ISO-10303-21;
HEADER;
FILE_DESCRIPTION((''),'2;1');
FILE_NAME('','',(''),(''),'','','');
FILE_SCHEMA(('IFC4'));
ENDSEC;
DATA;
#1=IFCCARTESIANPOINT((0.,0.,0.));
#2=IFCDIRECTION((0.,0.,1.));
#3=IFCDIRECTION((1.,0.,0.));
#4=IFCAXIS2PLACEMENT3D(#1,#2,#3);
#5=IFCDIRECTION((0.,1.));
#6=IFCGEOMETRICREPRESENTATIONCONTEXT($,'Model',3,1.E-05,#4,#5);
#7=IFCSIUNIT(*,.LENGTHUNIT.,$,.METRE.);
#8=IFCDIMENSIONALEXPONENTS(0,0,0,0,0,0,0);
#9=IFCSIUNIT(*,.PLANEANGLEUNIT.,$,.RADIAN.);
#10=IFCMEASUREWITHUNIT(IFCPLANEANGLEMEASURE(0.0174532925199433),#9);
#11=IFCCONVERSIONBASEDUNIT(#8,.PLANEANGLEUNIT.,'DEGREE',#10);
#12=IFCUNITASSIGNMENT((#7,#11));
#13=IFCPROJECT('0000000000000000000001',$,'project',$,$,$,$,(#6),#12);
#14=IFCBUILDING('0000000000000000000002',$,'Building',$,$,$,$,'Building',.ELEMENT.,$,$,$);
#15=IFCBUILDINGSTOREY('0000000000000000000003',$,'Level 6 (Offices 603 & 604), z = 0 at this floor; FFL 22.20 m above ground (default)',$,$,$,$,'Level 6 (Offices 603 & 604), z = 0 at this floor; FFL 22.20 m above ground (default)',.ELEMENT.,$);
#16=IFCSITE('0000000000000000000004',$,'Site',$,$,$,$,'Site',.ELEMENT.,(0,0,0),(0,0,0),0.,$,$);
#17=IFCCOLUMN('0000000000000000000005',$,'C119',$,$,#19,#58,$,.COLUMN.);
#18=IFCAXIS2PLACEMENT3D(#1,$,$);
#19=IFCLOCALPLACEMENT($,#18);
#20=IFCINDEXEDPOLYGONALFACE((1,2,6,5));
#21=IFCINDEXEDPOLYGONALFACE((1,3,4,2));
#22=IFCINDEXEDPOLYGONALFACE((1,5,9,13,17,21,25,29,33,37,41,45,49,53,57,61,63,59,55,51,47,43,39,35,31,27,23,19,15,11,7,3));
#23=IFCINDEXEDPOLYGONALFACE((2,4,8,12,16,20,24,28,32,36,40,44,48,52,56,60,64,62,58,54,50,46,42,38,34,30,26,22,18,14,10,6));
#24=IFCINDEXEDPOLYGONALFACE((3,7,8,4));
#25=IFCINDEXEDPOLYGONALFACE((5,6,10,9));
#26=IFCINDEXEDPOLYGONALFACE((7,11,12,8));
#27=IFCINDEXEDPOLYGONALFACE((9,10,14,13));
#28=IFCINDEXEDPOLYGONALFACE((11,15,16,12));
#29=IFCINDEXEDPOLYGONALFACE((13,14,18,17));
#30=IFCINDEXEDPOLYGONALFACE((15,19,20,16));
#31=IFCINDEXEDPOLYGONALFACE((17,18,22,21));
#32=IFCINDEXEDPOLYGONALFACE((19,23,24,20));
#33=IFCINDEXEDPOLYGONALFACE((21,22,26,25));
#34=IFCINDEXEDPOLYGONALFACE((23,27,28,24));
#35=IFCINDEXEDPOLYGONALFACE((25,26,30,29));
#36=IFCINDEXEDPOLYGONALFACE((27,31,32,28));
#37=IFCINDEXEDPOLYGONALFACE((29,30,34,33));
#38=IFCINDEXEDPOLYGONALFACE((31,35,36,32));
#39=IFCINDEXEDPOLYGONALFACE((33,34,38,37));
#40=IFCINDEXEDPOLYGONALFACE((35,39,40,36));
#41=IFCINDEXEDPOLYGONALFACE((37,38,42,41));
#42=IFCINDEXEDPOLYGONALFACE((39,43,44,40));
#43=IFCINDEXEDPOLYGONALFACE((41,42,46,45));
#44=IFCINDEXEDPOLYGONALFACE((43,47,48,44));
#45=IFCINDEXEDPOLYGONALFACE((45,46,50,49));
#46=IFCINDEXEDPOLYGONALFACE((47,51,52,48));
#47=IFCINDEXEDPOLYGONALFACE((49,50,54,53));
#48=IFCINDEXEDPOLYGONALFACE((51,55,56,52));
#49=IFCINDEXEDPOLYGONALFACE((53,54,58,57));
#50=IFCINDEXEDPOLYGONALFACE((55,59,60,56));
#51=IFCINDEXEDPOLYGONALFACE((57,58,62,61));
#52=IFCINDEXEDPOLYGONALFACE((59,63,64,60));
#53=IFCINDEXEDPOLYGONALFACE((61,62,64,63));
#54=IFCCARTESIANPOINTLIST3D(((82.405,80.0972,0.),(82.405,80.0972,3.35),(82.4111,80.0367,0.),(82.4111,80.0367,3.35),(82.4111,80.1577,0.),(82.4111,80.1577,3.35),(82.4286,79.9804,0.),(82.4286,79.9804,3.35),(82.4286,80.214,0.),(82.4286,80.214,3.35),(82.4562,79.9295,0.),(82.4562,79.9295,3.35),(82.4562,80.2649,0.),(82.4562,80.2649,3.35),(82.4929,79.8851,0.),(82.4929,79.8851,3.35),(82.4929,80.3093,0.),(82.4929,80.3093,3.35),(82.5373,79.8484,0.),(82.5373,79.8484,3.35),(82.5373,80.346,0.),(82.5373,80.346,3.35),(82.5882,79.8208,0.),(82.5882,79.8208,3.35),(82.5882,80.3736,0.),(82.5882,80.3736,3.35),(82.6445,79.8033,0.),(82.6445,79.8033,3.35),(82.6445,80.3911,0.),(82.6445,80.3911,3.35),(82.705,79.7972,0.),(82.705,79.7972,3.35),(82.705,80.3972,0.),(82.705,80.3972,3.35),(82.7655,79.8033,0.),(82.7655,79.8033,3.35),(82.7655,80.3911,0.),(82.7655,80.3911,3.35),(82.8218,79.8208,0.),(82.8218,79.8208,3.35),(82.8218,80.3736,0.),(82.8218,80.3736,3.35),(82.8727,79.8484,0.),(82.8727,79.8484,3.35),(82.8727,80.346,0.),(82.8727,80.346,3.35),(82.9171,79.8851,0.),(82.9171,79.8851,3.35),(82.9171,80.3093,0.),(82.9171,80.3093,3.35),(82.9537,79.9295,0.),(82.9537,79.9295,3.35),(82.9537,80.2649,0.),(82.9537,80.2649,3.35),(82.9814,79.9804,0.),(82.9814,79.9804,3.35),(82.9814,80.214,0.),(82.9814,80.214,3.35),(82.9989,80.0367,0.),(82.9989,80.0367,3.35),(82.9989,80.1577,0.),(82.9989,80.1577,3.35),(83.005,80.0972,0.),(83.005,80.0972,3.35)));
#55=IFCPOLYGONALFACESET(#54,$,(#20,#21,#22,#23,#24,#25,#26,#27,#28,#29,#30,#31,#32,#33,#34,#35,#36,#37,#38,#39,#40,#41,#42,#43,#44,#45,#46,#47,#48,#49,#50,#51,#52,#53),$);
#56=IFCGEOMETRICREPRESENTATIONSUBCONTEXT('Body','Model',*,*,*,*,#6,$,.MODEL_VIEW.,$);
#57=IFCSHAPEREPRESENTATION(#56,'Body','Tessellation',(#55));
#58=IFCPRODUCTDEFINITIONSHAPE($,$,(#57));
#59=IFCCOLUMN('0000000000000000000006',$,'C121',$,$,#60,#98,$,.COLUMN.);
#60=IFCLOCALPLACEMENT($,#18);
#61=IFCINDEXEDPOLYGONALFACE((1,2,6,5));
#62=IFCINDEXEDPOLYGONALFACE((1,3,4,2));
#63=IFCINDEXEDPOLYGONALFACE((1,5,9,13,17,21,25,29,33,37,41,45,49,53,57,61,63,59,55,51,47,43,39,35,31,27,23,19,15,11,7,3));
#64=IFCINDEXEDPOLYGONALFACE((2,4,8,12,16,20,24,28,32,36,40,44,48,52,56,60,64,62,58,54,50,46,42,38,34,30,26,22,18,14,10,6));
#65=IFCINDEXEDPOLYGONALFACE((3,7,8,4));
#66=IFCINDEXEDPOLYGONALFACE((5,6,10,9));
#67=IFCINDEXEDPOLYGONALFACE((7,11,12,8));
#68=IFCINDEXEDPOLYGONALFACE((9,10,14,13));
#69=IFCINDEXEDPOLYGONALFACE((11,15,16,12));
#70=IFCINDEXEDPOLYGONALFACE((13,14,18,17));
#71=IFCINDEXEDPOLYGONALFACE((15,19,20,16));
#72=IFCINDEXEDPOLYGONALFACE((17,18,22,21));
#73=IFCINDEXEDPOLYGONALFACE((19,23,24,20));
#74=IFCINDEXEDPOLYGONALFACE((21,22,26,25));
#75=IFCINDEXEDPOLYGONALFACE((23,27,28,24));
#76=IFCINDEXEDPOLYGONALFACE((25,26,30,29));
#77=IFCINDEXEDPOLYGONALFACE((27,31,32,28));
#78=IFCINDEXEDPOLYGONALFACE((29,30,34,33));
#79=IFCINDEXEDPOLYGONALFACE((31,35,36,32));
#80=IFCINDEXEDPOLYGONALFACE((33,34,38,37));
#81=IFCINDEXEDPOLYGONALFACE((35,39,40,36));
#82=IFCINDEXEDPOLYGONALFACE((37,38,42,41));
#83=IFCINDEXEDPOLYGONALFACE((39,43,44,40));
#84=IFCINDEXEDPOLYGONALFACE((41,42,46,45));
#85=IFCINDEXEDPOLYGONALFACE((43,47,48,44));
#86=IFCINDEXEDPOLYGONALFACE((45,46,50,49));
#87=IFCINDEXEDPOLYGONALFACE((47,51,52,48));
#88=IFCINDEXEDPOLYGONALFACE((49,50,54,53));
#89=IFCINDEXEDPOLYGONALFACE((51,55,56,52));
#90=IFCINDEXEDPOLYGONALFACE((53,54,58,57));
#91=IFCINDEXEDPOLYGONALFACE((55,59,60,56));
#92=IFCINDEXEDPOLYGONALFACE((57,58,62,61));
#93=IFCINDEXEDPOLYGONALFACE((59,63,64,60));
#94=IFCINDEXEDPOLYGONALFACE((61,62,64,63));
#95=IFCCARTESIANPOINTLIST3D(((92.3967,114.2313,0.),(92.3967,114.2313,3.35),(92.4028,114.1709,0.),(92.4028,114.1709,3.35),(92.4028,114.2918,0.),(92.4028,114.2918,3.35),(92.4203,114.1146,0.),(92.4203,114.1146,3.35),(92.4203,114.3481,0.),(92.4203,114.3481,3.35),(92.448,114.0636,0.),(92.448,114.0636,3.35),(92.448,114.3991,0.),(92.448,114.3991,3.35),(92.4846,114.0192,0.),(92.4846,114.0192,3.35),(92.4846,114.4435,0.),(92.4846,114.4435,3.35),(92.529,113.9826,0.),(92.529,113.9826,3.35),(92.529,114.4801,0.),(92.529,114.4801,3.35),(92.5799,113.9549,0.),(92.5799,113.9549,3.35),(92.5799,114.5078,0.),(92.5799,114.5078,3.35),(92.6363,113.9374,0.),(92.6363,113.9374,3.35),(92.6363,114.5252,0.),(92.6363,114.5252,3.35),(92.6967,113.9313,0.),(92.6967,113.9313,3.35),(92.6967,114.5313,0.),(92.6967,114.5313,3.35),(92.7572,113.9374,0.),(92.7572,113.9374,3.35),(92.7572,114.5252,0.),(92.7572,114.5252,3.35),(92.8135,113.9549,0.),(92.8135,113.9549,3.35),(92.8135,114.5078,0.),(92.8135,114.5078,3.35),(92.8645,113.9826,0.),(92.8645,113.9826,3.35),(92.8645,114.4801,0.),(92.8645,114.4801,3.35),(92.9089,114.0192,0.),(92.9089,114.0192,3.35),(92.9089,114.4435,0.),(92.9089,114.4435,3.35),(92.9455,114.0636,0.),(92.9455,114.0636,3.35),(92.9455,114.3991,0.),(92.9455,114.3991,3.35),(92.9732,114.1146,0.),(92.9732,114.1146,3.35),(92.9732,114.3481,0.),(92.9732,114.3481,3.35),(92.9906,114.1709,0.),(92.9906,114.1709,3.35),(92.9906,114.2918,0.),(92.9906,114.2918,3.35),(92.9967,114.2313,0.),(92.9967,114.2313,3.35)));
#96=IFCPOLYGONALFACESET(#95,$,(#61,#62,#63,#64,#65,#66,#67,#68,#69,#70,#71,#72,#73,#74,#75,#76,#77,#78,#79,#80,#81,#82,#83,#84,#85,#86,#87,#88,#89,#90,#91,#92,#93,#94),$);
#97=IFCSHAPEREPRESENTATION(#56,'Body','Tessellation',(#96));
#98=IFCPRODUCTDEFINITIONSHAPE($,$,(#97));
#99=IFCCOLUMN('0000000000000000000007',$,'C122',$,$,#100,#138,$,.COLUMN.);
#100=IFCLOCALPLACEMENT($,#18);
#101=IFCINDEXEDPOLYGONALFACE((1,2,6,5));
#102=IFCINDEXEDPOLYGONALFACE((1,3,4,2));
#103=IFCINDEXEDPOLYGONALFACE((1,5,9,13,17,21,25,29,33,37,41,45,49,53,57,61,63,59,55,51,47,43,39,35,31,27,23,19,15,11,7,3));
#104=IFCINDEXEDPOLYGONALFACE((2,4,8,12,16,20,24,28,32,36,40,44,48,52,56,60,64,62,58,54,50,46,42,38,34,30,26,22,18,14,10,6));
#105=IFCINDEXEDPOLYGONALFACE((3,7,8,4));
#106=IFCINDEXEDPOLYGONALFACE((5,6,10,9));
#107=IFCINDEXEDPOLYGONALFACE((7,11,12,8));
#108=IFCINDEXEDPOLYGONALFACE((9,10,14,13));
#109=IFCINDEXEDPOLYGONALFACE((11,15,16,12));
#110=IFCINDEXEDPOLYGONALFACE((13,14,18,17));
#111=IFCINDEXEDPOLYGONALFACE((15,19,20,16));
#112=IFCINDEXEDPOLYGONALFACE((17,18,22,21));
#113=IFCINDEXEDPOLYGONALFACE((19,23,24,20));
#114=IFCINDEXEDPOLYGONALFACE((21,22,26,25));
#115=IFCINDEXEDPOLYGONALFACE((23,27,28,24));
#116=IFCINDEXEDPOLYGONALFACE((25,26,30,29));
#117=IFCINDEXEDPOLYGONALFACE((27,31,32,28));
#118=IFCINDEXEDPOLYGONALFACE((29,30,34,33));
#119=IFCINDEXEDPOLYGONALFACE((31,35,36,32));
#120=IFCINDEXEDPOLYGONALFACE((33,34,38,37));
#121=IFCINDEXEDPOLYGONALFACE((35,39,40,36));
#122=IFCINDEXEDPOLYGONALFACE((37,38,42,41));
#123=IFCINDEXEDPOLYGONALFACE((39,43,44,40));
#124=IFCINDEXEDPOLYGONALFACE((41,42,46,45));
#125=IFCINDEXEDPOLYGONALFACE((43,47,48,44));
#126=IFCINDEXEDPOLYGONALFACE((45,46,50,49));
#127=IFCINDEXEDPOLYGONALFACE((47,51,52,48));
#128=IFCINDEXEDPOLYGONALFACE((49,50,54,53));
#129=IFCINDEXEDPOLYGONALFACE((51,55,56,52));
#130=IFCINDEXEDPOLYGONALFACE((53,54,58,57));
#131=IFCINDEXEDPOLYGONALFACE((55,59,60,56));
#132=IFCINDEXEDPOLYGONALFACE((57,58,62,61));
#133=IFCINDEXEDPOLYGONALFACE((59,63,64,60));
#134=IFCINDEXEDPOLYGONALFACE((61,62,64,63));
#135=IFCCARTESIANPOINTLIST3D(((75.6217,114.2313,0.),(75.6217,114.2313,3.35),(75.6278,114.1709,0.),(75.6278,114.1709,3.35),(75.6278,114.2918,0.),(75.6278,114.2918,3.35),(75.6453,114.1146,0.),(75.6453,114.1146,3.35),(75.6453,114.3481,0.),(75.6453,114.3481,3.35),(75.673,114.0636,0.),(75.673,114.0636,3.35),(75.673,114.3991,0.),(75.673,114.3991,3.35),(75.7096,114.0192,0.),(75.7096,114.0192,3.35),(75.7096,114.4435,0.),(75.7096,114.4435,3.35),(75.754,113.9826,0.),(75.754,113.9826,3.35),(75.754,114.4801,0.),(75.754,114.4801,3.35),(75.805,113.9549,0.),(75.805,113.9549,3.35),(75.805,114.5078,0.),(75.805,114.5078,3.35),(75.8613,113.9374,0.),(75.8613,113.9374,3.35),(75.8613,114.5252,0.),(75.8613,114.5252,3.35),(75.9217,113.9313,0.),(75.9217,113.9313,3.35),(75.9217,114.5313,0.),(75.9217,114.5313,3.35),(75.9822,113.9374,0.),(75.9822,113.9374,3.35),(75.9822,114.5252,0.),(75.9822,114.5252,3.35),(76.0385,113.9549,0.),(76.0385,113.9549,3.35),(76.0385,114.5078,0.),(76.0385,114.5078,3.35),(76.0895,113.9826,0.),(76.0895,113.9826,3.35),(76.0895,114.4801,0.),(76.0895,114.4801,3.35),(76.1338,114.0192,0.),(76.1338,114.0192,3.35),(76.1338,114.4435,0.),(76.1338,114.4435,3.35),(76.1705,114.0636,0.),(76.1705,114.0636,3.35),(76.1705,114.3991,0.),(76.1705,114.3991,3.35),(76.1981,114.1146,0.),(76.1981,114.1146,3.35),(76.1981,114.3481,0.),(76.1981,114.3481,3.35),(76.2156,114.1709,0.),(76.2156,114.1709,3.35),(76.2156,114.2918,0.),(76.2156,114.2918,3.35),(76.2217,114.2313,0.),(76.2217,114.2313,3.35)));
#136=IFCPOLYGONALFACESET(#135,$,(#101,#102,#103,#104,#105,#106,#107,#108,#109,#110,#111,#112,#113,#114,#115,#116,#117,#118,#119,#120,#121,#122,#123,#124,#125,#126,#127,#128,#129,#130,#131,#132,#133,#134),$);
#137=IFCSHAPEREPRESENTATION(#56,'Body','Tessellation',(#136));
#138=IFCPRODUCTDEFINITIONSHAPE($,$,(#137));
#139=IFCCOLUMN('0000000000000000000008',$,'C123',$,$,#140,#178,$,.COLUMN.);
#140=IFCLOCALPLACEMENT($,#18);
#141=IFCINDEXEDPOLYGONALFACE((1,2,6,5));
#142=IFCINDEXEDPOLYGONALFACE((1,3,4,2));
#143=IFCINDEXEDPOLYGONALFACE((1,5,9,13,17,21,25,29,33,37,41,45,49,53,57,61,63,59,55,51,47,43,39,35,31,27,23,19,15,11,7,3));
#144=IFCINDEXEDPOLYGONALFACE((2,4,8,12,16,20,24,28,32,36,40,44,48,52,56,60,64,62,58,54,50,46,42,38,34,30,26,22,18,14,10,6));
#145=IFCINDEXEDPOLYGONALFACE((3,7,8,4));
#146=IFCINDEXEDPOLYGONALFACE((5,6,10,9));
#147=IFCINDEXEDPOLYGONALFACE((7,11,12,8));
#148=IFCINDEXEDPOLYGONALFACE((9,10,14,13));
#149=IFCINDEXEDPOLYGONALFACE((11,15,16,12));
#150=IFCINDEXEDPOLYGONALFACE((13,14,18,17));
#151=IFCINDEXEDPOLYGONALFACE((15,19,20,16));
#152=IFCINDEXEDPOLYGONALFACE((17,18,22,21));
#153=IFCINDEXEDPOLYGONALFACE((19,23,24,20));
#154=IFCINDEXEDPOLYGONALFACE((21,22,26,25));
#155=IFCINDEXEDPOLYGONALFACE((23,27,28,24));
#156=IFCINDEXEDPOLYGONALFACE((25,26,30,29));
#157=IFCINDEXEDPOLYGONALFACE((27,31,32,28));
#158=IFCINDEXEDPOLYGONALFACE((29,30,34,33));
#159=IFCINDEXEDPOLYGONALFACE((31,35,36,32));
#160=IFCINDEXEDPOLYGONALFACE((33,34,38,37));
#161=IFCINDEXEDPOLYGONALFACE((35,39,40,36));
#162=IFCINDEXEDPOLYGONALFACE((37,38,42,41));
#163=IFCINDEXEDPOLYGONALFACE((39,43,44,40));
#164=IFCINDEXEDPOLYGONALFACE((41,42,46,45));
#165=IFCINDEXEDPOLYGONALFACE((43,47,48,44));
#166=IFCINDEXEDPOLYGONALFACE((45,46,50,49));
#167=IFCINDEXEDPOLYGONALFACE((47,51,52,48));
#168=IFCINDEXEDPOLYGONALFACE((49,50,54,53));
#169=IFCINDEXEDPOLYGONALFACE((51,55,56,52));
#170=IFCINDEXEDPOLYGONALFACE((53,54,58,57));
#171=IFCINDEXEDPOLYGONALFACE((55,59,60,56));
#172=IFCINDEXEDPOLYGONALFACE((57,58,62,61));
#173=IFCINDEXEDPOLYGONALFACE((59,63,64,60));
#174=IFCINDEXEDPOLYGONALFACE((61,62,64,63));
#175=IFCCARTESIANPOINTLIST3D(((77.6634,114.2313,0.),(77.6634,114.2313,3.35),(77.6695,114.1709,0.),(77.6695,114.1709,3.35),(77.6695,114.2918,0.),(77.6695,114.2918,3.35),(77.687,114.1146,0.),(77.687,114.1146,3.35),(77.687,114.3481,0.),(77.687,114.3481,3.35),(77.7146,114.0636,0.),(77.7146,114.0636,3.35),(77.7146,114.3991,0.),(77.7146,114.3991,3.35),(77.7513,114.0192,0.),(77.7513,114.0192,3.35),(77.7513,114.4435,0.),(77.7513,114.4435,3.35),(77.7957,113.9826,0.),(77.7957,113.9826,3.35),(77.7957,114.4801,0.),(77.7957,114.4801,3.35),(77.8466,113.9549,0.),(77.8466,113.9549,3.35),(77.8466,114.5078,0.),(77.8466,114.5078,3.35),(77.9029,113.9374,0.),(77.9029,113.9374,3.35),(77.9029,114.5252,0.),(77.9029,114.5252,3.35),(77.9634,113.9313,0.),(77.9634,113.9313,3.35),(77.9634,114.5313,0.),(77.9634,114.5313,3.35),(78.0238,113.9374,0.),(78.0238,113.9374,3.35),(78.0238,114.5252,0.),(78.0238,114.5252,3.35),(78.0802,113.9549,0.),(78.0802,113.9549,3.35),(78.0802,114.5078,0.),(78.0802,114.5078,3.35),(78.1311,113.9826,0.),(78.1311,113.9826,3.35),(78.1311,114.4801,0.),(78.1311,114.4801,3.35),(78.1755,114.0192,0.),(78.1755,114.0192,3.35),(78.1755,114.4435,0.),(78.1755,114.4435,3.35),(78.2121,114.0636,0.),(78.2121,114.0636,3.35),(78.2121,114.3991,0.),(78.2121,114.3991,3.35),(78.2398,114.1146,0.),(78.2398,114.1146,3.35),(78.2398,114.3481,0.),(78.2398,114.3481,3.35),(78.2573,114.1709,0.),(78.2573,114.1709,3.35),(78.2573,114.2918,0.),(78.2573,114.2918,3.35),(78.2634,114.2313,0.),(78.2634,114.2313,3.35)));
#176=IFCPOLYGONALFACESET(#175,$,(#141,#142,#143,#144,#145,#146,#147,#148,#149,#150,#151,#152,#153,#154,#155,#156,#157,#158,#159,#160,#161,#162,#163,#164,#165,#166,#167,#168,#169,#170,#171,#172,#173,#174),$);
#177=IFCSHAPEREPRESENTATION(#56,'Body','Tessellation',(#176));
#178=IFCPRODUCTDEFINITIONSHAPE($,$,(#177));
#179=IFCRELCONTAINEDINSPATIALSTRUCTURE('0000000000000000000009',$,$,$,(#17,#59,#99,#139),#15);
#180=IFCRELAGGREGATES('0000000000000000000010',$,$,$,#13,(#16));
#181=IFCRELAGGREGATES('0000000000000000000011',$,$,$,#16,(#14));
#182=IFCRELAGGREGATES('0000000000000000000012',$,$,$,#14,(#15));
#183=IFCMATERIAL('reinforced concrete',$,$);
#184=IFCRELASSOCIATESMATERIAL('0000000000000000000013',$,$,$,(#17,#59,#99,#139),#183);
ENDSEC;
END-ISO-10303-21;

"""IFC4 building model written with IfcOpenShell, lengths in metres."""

from ifc_helpers import new_model, entity, si_unit, converted_unit, direction, frame, origin_with_axes, place, context, subcontext, project, spatial, polyline, outline, extrude, material, element, save


model = new_model("IFC4")

# Units and contexts
model_context = context("Model", 3, precision=1e-05, world=origin_with_axes(), true_north=direction((0.0, 1.0)))
body_context = subcontext(model_context, "Body", "Model", "MODEL_VIEW")
ifc_project = project(units=[si_unit("LENGTHUNIT", "METRE"), converted_unit("PLANEANGLEUNIT", "DEGREE", entity("IfcPlaneAngleMeasure", 0.0174532925199433), si_unit("PLANEANGLEUNIT", "RADIAN"), dimensions=[0, 0, 0, 0, 0, 0, 0])], contexts=[model_context])

# Site, building, storey
site = spatial("IfcSite", under=ifc_project, Name="Site", LongName="Site", CompositionType="ELEMENT", RefLatitude=(0, 0, 0), RefLongitude=(0, 0, 0), RefElevation=0.0)
building = spatial("IfcBuilding", under=site, Name="Building", LongName="Building", CompositionType="ELEMENT")
storey = spatial("IfcBuildingStorey", under=building, Name="Level 6 (Offices 603 & 604), z = 0 at this floor; FFL 22.20 m above ground (default)", LongName="Level 6 (Offices 603 & 604), z = 0 at this floor; FFL 22.20 m above ground (default)", CompositionType="ELEMENT")

# Columns
ifc_material_1 = material(Name="reinforced concrete")
placement = place(None, origin_with_axes())
element("IfcColumn", 1, at=placement, inside=storey, material=ifc_material_1, Name="C119", PredefinedType="COLUMN", context=body_context, shape_type="SweptSolid", body=[
    extrude(outline(polyline([(0.3, 0.0), (0.2939, -0.0605), (0.2764, -0.1168), (0.2487, -0.1677), (0.2121, -0.2121), (0.1677, -0.2488), (0.1168, -0.2764), (0.0605, -0.2939), (0.0, -0.3), (-0.0605, -0.2939), (-0.1168, -0.2764), (-0.1677, -0.2488), (-0.2121, -0.2121), (-0.2488, -0.1677), (-0.2764, -0.1168), (-0.2939, -0.0605), (-0.3, 0.0), (-0.2939, 0.0605), (-0.2764, 0.1168), (-0.2488, 0.1677), (-0.2121, 0.2121), (-0.1677, 0.2488), (-0.1168, 0.2764), (-0.0605, 0.2939), (0.0, 0.3), (0.0605, 0.2939), (0.1168, 0.2764), (0.1677, 0.2488), (0.2121, 0.2121), (0.2487, 0.1677), (0.2764, 0.1168), (0.2939, 0.0605), (0.3, 0.0)])), frame((82.705, 80.0972, 0.0), z_axis=(0.0, 0.0, 1.0), x_axis=(1.0, 0.0, 0.0)), (0.0, 0.0, 1.0), 3.35),
])
element("IfcColumn", 2, at=placement, inside=storey, material=ifc_material_1, Name="C121", PredefinedType="COLUMN", context=body_context, shape_type="SweptSolid", body=[
    extrude(outline(polyline([(0.3, 0.0), (0.2939, -0.0604), (0.2765, -0.1167), (0.2488, -0.1677), (0.2122, -0.2121), (0.1678, -0.2487), (0.1168, -0.2764), (0.0605, -0.2939), (0.0, -0.3), (-0.0604, -0.2939), (-0.1168, -0.2764), (-0.1677, -0.2487), (-0.2121, -0.2121), (-0.2487, -0.1677), (-0.2764, -0.1167), (-0.2939, -0.0604), (-0.3, 0.0), (-0.2939, 0.0605), (-0.2764, 0.1168), (-0.2487, 0.1678), (-0.2121, 0.2122), (-0.1677, 0.2488), (-0.1168, 0.2765), (-0.0604, 0.2939), (0.0, 0.3), (0.0605, 0.2939), (0.1168, 0.2765), (0.1678, 0.2488), (0.2122, 0.2122), (0.2488, 0.1678), (0.2765, 0.1168), (0.2939, 0.0605), (0.3, 0.0)])), frame((92.6967, 114.2313, 0.0), z_axis=(0.0, 0.0, 1.0), x_axis=(1.0, 0.0, 0.0)), (0.0, 0.0, 1.0), 3.35),
])
element("IfcColumn", 3, at=placement, inside=storey, material=ifc_material_1, Name="C122", PredefinedType="COLUMN", context=body_context, shape_type="SweptSolid", body=[
    extrude(outline(polyline([(0.3, 0.0), (0.2939, -0.0604), (0.2764, -0.1167), (0.2488, -0.1677), (0.2121, -0.2121), (0.1678, -0.2487), (0.1168, -0.2764), (0.0605, -0.2939), (0.0, -0.3), (-0.0604, -0.2939), (-0.1167, -0.2764), (-0.1677, -0.2487), (-0.2121, -0.2121), (-0.2487, -0.1677), (-0.2764, -0.1167), (-0.2939, -0.0604), (-0.3, 0.0), (-0.2939, 0.0605), (-0.2764, 0.1168), (-0.2487, 0.1678), (-0.2121, 0.2122), (-0.1677, 0.2488), (-0.1167, 0.2765), (-0.0604, 0.2939), (0.0, 0.3), (0.0605, 0.2939), (0.1168, 0.2765), (0.1678, 0.2488), (0.2121, 0.2122), (0.2488, 0.1678), (0.2764, 0.1168), (0.2939, 0.0605), (0.3, 0.0)])), frame((75.9217, 114.2313, 0.0), z_axis=(0.0, 0.0, 1.0), x_axis=(1.0, 0.0, 0.0)), (0.0, 0.0, 1.0), 3.35),
])
element("IfcColumn", 4, at=placement, inside=storey, material=ifc_material_1, Name="C123", PredefinedType="COLUMN", context=body_context, shape_type="SweptSolid", body=[
    extrude(outline(polyline([(0.3, 0.0), (0.2939, -0.0604), (0.2764, -0.1167), (0.2487, -0.1677), (0.2121, -0.2121), (0.1677, -0.2487), (0.1168, -0.2764), (0.0604, -0.2939), (0.0, -0.3), (-0.0605, -0.2939), (-0.1168, -0.2764), (-0.1677, -0.2487), (-0.2121, -0.2121), (-0.2488, -0.1677), (-0.2764, -0.1167), (-0.2939, -0.0604), (-0.3, 0.0), (-0.2939, 0.0605), (-0.2764, 0.1168), (-0.2488, 0.1678), (-0.2121, 0.2122), (-0.1677, 0.2488), (-0.1168, 0.2765), (-0.0605, 0.2939), (0.0, 0.3), (0.0604, 0.2939), (0.1168, 0.2765), (0.1677, 0.2488), (0.2121, 0.2122), (0.2487, 0.1678), (0.2764, 0.1168), (0.2939, 0.0605), (0.3, 0.0)])), frame((77.9634, 114.2313, 0.0), z_axis=(0.0, 0.0, 1.0), x_axis=(1.0, 0.0, 0.0)), (0.0, 0.0, 1.0), 3.35),
])

save(model, "model.ifc")
